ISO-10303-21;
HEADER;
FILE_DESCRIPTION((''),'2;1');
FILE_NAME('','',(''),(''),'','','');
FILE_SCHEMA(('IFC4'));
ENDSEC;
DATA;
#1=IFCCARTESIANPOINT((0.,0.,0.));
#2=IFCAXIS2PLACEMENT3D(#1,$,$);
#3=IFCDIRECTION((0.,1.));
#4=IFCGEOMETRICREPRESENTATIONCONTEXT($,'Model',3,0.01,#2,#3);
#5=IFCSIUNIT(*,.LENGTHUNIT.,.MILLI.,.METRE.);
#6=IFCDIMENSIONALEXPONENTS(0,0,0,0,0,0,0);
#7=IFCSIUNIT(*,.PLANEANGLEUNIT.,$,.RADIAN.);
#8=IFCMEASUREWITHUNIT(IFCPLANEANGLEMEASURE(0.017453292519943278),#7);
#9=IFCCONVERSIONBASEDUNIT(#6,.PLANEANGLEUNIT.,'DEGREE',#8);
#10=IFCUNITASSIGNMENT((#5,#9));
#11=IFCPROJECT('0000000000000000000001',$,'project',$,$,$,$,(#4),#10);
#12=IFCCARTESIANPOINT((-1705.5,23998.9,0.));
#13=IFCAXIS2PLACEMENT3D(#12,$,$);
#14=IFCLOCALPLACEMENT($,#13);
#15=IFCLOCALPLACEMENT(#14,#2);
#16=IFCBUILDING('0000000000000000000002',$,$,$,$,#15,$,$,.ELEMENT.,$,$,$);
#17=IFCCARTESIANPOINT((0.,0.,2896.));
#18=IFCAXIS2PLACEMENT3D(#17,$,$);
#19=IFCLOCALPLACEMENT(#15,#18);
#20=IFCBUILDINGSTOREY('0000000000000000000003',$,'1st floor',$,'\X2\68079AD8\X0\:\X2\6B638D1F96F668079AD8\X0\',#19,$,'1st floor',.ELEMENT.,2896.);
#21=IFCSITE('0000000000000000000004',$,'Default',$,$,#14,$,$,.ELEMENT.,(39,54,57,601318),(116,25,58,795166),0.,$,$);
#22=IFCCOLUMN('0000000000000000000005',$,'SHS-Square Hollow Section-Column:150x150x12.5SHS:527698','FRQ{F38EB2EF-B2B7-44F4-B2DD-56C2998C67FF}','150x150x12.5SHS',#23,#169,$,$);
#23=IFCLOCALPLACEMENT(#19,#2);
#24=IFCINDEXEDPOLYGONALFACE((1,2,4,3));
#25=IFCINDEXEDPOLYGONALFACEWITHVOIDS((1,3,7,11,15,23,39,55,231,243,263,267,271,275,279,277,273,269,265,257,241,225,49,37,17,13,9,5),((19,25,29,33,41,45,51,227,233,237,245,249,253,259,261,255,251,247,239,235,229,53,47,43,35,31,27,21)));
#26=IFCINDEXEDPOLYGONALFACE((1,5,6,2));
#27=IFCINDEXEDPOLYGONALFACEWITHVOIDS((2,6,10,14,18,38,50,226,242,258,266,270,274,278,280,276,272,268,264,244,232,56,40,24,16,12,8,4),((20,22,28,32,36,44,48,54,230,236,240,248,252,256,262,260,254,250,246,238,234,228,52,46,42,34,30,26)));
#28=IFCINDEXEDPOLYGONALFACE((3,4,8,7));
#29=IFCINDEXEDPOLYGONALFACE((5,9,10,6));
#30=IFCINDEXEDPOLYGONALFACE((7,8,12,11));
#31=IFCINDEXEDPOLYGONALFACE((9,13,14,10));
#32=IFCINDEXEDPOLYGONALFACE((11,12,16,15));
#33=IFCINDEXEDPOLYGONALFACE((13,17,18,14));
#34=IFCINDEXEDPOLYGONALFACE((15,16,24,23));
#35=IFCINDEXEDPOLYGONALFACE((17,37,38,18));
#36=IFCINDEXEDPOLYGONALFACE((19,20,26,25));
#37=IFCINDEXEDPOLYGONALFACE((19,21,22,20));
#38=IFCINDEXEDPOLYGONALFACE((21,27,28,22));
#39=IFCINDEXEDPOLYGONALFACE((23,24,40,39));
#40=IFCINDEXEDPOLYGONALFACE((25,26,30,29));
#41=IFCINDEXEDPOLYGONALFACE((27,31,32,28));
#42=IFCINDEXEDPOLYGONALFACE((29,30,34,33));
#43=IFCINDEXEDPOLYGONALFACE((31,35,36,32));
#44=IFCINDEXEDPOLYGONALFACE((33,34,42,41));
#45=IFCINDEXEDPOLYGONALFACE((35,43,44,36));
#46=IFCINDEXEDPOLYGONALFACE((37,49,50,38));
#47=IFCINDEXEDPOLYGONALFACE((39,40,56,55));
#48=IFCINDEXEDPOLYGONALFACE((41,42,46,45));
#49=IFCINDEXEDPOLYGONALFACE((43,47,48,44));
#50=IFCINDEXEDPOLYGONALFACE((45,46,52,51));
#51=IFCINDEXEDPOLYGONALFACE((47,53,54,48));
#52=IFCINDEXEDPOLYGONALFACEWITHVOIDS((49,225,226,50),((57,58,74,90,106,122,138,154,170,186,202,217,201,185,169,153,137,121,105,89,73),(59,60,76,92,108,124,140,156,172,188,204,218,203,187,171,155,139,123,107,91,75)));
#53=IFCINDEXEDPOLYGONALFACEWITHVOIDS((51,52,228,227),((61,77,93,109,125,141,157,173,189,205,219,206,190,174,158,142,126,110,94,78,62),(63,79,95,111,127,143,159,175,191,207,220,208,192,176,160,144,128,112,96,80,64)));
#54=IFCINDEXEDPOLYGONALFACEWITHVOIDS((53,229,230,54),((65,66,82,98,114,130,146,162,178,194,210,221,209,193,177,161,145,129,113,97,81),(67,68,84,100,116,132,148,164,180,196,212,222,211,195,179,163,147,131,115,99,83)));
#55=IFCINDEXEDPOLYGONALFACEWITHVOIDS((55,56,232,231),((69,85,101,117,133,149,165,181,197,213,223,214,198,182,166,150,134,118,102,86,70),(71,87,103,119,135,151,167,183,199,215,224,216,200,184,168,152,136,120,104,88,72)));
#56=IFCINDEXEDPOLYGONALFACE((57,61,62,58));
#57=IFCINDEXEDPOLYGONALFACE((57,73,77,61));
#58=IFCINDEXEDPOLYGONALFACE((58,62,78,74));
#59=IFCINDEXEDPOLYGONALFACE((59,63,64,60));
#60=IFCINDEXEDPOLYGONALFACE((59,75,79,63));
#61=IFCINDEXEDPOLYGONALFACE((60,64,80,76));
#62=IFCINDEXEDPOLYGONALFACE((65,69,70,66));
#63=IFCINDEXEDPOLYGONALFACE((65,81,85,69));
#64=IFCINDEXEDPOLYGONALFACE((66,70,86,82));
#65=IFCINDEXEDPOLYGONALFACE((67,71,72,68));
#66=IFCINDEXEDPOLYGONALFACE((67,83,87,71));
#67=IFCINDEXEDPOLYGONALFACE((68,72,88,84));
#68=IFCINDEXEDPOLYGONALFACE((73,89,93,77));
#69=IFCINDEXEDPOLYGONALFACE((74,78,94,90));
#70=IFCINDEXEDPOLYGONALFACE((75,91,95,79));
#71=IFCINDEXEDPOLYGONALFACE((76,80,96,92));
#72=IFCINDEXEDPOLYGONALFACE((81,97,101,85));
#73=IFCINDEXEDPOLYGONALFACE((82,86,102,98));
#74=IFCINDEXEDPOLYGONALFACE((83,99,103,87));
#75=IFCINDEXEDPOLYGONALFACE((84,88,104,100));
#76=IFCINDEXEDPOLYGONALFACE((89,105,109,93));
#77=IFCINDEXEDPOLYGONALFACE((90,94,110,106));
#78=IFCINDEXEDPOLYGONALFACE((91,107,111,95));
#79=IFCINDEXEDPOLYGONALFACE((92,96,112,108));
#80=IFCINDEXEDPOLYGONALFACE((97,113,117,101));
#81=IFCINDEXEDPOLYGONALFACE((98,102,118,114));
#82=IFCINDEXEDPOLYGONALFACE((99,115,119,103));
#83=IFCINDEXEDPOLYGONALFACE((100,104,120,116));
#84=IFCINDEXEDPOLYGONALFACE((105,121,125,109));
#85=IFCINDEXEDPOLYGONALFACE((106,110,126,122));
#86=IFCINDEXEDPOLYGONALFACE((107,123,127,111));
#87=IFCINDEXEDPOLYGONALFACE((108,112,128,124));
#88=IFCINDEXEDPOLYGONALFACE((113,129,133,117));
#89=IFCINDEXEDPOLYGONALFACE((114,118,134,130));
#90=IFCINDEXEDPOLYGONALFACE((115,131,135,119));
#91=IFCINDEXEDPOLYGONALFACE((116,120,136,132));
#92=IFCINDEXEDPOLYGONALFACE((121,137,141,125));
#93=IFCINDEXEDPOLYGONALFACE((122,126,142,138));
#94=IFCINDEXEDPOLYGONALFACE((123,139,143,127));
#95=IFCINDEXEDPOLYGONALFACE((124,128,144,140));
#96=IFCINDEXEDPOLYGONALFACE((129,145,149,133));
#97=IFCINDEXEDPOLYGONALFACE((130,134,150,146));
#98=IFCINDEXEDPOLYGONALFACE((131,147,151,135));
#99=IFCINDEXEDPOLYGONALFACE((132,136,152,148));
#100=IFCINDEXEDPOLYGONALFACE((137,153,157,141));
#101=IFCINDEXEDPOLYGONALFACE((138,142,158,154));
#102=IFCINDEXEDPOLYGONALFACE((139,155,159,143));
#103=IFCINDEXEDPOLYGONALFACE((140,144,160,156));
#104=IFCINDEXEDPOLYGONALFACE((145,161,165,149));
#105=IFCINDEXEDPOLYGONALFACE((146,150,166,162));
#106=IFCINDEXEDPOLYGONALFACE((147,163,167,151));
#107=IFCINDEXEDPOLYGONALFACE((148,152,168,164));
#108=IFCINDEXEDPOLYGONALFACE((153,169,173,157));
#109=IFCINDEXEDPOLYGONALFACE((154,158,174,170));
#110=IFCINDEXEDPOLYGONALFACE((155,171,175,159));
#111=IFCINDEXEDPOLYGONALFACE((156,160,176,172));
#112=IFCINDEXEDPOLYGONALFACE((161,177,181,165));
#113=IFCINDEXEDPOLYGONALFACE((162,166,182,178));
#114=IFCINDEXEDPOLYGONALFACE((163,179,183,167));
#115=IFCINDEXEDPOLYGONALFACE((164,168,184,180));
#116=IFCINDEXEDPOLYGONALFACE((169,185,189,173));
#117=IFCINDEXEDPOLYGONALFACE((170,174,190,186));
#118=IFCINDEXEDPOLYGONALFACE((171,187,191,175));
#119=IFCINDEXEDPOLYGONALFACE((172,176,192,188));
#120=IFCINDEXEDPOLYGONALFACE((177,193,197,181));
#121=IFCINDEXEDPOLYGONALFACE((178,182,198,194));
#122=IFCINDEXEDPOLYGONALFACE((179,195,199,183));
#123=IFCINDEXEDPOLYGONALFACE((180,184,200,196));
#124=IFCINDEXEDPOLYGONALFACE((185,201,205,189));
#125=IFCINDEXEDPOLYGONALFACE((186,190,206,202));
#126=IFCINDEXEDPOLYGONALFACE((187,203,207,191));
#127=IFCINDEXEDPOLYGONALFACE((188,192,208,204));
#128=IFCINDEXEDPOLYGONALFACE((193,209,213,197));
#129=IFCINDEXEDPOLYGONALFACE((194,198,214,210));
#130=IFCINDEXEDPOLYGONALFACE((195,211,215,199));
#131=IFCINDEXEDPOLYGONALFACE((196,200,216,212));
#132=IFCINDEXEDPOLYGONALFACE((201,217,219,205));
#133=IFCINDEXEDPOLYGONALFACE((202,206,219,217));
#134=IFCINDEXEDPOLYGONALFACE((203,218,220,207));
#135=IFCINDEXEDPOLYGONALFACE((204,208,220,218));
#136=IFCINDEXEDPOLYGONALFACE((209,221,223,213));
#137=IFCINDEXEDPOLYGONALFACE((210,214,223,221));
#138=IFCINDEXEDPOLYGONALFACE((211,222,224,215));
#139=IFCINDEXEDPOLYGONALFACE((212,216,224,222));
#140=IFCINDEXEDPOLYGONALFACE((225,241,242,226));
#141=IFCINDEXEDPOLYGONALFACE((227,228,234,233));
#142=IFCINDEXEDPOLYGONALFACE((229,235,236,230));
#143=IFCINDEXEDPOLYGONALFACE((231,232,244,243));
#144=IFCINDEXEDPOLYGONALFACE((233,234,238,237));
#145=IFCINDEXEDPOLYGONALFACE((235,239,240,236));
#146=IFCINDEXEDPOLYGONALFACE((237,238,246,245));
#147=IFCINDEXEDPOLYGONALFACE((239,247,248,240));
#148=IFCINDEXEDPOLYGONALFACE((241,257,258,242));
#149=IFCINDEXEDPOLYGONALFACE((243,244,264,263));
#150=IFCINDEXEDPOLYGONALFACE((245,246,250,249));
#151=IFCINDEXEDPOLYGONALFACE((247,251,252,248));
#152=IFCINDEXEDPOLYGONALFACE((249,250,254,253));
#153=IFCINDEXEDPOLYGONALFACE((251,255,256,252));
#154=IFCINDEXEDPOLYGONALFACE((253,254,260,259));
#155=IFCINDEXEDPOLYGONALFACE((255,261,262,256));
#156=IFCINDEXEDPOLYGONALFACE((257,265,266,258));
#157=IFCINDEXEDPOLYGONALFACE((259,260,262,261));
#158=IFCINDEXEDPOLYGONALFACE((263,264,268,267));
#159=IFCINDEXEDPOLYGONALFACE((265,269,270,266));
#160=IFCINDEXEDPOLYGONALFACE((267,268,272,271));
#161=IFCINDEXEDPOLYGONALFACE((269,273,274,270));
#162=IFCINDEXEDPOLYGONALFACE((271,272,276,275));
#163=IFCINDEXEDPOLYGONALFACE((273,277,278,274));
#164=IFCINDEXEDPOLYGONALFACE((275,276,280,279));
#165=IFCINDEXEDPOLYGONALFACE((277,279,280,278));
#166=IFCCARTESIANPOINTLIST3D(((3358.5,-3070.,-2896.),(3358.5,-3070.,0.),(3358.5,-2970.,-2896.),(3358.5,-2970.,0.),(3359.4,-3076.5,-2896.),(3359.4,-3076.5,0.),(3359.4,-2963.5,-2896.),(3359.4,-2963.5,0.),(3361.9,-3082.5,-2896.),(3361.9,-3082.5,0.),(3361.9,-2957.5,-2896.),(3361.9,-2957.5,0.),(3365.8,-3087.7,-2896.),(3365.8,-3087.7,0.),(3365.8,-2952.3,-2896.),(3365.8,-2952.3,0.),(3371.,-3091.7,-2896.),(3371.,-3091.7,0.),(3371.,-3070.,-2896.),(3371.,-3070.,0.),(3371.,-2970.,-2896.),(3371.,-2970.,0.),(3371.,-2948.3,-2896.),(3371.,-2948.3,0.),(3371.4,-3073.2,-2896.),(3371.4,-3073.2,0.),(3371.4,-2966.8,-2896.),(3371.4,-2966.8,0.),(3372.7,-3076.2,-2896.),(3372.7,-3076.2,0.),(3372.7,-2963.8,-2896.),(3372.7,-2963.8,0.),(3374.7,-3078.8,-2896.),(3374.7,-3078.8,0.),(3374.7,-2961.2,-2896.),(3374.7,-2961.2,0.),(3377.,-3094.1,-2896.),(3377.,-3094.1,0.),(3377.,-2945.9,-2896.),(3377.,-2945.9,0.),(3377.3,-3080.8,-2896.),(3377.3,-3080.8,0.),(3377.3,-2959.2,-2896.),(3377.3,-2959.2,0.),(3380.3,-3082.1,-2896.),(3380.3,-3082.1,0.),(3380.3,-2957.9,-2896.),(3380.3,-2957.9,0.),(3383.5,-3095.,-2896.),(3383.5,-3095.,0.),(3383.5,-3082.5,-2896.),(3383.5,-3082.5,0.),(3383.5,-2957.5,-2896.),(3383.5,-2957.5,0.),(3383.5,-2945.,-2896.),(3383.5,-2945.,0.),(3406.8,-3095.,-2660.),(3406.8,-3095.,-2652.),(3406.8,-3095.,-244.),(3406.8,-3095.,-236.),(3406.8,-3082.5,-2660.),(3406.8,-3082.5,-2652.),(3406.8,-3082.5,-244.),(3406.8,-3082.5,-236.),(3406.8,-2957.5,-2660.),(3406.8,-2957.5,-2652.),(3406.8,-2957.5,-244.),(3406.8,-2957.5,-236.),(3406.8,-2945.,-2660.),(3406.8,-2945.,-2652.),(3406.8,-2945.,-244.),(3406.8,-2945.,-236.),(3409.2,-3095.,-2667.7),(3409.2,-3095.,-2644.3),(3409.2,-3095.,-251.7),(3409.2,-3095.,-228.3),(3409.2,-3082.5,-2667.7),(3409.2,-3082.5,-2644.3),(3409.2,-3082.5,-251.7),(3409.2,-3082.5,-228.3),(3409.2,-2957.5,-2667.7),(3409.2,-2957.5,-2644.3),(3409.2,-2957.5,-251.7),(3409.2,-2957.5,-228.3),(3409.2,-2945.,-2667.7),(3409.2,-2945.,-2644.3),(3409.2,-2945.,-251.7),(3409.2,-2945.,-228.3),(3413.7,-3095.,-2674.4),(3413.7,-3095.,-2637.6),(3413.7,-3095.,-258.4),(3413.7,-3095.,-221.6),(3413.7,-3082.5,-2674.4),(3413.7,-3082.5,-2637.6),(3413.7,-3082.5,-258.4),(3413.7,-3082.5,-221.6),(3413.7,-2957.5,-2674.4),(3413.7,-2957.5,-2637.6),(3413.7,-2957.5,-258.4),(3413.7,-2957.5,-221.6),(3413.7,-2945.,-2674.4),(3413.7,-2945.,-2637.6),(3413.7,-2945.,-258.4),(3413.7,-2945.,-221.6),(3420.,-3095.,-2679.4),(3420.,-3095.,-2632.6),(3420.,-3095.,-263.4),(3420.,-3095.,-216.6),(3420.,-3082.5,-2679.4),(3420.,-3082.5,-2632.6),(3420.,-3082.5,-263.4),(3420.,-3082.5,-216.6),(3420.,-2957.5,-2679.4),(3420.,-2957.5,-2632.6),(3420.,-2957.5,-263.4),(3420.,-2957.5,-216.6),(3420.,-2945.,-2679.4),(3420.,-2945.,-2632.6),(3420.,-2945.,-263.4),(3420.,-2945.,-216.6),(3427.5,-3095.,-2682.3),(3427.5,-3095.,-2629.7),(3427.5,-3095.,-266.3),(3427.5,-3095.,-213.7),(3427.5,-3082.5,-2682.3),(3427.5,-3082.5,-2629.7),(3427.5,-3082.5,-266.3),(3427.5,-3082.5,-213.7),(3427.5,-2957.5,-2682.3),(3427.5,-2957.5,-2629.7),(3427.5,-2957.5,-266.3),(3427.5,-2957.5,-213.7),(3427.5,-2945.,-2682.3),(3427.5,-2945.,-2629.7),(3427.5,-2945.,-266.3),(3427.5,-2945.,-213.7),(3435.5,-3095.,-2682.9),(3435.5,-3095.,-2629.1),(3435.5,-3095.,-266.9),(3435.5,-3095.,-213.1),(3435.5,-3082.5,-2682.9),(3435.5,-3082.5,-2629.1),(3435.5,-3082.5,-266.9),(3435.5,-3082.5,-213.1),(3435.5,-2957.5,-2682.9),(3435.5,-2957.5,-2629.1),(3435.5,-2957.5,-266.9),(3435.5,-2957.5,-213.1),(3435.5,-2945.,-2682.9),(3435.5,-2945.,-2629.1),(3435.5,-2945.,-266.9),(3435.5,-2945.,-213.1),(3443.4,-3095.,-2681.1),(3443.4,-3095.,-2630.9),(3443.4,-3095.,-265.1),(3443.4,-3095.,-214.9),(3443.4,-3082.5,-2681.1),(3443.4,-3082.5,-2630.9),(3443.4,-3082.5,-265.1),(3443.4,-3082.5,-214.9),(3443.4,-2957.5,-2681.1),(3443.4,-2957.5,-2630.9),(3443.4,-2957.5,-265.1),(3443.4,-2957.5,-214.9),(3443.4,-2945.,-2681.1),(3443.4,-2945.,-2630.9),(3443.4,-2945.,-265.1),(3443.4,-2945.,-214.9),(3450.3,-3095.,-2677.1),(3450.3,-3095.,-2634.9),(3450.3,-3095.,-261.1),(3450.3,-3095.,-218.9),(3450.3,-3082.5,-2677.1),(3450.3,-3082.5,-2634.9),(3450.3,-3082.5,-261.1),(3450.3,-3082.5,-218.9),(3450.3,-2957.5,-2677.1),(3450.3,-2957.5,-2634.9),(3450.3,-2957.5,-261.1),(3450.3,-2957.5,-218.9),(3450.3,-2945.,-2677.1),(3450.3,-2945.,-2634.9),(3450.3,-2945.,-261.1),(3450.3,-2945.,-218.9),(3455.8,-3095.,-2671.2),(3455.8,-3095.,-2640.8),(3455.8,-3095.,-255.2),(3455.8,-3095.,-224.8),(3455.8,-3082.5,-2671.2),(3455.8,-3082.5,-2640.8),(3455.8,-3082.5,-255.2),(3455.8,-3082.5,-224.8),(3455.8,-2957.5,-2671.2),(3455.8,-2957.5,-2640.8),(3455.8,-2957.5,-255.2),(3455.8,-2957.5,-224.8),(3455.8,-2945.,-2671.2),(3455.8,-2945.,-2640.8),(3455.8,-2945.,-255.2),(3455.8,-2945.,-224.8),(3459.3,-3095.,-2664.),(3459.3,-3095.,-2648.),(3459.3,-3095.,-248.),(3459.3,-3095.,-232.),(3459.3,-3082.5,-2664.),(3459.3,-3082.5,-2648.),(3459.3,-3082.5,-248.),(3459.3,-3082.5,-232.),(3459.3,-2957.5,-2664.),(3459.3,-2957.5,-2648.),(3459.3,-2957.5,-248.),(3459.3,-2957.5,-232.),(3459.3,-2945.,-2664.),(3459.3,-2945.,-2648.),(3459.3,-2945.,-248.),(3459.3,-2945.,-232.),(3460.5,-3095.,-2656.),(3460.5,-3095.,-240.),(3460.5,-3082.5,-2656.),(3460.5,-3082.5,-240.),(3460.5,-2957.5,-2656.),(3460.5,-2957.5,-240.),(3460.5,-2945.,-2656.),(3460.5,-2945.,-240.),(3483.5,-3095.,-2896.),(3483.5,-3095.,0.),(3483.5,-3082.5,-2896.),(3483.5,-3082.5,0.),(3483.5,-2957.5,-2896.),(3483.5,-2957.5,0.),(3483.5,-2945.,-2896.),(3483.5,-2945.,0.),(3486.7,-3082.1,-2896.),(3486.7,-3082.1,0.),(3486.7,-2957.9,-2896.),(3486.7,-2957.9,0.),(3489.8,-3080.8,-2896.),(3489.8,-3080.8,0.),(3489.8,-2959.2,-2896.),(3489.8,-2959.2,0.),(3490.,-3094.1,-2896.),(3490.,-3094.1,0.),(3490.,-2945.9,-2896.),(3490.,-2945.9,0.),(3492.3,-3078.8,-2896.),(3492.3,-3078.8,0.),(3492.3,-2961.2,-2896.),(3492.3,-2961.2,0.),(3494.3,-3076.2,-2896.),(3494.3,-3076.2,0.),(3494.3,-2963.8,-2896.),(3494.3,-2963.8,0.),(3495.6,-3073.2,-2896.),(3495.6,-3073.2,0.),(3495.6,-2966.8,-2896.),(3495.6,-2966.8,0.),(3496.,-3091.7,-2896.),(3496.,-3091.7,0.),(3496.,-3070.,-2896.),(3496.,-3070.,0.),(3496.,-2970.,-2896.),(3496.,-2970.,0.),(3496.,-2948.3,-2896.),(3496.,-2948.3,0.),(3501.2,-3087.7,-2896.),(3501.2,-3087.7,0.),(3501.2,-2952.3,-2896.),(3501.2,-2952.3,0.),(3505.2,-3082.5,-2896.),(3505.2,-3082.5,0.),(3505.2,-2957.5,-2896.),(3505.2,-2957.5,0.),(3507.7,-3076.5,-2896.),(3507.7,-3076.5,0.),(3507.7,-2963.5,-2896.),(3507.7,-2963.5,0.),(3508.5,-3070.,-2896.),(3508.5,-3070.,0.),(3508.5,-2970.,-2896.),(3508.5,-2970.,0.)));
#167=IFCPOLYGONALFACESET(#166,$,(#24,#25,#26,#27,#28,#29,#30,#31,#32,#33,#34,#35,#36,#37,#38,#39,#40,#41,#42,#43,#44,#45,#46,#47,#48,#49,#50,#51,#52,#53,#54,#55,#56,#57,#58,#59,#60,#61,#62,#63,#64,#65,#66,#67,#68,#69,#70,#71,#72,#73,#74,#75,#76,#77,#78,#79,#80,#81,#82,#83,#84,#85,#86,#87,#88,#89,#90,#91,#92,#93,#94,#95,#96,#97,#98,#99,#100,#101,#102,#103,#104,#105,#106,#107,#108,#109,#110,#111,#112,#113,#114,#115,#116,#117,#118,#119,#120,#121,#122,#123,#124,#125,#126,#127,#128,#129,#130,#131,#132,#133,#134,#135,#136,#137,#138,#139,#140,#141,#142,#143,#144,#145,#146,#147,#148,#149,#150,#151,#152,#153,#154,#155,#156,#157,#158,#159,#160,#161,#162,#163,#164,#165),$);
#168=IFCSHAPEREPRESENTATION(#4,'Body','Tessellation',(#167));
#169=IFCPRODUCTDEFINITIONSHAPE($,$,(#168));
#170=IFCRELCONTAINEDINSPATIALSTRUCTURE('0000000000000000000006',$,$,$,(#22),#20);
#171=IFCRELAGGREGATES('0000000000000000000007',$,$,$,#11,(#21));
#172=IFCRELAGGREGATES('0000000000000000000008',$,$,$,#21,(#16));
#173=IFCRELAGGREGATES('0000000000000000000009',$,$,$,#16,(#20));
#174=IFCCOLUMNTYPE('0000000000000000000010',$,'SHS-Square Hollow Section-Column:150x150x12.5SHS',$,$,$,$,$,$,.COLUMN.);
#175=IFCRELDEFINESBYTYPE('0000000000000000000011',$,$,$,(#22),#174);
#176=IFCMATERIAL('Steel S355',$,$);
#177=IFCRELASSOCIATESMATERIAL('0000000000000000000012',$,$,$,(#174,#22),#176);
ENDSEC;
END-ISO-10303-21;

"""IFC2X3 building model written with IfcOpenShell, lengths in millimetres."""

from ifc_helpers import new_model, entity, si_unit, converted_unit, direction, frame, frame_2d, origin, origin_2d, place, context, project, spatial, circle_curve, hollow_rectangle, outline, extrude, material, type_object, element, save


model = new_model("IFC2X3")

# Units and contexts
model_context = context("Model", 3, precision=0.01, world=origin(), true_north=direction((0.0, 1.0)))
ifc_project = project(units=[si_unit("LENGTHUNIT", "METRE", prefix="MILLI"), converted_unit("PLANEANGLEUNIT", "DEGREE", entity("IfcPlaneAngleMeasure", 0.017453292519943278), si_unit("PLANEANGLEUNIT", "RADIAN"), dimensions=[0, 0, 0, 0, 0, 0, 0])], contexts=[model_context])

# Site, building, storey
site_placement = place(None, frame((-1705.5, 23998.9, 0.0)))
site = spatial("IfcSite", under=ifc_project, at=site_placement, Name="Default", CompositionType="ELEMENT", RefLatitude=(39, 54, 57, 601318), RefLongitude=(116, 25, 58, 795166), RefElevation=0.0)
building_placement = place(site_placement, origin())
building = spatial("IfcBuilding", under=site, at=building_placement, CompositionType="ELEMENT")
storey_placement = place(building_placement, frame((0.0, 0.0, 2896.0)))
storey = spatial("IfcBuildingStorey", under=building, at=storey_placement, Name="1st floor", ObjectType="标高:正负零标高", LongName="1st floor", CompositionType="ELEMENT", Elevation=2896.0)

# Column, openings
ifc_material_1 = material(Name="Steel S355")
column_type_1 = type_object("IfcColumnType", Name="SHS-Square Hollow Section-Column:150x150x12.5SHS", PredefinedType="COLUMN", material=ifc_material_1)
column_1_placement = place(storey_placement, frame((3433.5, -3020.0, 0.0), z_axis=(0.0, 0.0, 1.0), x_axis=(0.0, -1.0, 0.0)))
column_1 = element("IfcColumn", 1, at=column_1_placement, inside=storey, type_object=column_type_1, material=ifc_material_1, Name="SHS-Square Hollow Section-Column:150x150x12.5SHS:527698", Description="FRQ{F38EB2EF-B2B7-44F4-B2DD-56C2998C67FF}", ObjectType="150x150x12.5SHS", context=model_context, shape_type="SweptSolid", body=[
    extrude(hollow_rectangle(XDim=150.0, YDim=150.0, WallThickness=12.5, InnerFilletRadius=12.5, OuterFilletRadius=25.0, at=origin_2d()), origin(), (0.0, 0.0, -1.0), 2896.0),
])
opening_1_placement = place(column_1_placement, frame((-175.1, 0.0, 0.0), z_axis=(1.0, 0.0, 0.0), x_axis=(0.0, 1.0, 0.0)))
element("IfcOpeningElement", 2, at=opening_1_placement, cuts=column_1, ObjectType="Opening", context=model_context, shape_type="SweptSolid", body=[
    extrude(outline(circle_curve(frame_2d((0.0, -240.0), x_axis=(1.0, 0.0)), 27.0)), origin(), (0.0, 0.0, 1.0), 350.2),
])
opening_2_placement = place(column_1_placement, frame((-175.1, 0.0, -2896.0), z_axis=(1.0, 0.0, 0.0), x_axis=(0.0, 1.0, 0.0)))
element("IfcOpeningElement", 3, at=opening_2_placement, cuts=column_1, ObjectType="Opening", context=model_context, shape_type="SweptSolid", body=[
    extrude(outline(circle_curve(frame_2d((0.0, 240.0), x_axis=(1.0, 0.0)), 27.0)), origin(), (0.0, 0.0, 1.0), 350.2),
])

save(model, "model.ifc")
